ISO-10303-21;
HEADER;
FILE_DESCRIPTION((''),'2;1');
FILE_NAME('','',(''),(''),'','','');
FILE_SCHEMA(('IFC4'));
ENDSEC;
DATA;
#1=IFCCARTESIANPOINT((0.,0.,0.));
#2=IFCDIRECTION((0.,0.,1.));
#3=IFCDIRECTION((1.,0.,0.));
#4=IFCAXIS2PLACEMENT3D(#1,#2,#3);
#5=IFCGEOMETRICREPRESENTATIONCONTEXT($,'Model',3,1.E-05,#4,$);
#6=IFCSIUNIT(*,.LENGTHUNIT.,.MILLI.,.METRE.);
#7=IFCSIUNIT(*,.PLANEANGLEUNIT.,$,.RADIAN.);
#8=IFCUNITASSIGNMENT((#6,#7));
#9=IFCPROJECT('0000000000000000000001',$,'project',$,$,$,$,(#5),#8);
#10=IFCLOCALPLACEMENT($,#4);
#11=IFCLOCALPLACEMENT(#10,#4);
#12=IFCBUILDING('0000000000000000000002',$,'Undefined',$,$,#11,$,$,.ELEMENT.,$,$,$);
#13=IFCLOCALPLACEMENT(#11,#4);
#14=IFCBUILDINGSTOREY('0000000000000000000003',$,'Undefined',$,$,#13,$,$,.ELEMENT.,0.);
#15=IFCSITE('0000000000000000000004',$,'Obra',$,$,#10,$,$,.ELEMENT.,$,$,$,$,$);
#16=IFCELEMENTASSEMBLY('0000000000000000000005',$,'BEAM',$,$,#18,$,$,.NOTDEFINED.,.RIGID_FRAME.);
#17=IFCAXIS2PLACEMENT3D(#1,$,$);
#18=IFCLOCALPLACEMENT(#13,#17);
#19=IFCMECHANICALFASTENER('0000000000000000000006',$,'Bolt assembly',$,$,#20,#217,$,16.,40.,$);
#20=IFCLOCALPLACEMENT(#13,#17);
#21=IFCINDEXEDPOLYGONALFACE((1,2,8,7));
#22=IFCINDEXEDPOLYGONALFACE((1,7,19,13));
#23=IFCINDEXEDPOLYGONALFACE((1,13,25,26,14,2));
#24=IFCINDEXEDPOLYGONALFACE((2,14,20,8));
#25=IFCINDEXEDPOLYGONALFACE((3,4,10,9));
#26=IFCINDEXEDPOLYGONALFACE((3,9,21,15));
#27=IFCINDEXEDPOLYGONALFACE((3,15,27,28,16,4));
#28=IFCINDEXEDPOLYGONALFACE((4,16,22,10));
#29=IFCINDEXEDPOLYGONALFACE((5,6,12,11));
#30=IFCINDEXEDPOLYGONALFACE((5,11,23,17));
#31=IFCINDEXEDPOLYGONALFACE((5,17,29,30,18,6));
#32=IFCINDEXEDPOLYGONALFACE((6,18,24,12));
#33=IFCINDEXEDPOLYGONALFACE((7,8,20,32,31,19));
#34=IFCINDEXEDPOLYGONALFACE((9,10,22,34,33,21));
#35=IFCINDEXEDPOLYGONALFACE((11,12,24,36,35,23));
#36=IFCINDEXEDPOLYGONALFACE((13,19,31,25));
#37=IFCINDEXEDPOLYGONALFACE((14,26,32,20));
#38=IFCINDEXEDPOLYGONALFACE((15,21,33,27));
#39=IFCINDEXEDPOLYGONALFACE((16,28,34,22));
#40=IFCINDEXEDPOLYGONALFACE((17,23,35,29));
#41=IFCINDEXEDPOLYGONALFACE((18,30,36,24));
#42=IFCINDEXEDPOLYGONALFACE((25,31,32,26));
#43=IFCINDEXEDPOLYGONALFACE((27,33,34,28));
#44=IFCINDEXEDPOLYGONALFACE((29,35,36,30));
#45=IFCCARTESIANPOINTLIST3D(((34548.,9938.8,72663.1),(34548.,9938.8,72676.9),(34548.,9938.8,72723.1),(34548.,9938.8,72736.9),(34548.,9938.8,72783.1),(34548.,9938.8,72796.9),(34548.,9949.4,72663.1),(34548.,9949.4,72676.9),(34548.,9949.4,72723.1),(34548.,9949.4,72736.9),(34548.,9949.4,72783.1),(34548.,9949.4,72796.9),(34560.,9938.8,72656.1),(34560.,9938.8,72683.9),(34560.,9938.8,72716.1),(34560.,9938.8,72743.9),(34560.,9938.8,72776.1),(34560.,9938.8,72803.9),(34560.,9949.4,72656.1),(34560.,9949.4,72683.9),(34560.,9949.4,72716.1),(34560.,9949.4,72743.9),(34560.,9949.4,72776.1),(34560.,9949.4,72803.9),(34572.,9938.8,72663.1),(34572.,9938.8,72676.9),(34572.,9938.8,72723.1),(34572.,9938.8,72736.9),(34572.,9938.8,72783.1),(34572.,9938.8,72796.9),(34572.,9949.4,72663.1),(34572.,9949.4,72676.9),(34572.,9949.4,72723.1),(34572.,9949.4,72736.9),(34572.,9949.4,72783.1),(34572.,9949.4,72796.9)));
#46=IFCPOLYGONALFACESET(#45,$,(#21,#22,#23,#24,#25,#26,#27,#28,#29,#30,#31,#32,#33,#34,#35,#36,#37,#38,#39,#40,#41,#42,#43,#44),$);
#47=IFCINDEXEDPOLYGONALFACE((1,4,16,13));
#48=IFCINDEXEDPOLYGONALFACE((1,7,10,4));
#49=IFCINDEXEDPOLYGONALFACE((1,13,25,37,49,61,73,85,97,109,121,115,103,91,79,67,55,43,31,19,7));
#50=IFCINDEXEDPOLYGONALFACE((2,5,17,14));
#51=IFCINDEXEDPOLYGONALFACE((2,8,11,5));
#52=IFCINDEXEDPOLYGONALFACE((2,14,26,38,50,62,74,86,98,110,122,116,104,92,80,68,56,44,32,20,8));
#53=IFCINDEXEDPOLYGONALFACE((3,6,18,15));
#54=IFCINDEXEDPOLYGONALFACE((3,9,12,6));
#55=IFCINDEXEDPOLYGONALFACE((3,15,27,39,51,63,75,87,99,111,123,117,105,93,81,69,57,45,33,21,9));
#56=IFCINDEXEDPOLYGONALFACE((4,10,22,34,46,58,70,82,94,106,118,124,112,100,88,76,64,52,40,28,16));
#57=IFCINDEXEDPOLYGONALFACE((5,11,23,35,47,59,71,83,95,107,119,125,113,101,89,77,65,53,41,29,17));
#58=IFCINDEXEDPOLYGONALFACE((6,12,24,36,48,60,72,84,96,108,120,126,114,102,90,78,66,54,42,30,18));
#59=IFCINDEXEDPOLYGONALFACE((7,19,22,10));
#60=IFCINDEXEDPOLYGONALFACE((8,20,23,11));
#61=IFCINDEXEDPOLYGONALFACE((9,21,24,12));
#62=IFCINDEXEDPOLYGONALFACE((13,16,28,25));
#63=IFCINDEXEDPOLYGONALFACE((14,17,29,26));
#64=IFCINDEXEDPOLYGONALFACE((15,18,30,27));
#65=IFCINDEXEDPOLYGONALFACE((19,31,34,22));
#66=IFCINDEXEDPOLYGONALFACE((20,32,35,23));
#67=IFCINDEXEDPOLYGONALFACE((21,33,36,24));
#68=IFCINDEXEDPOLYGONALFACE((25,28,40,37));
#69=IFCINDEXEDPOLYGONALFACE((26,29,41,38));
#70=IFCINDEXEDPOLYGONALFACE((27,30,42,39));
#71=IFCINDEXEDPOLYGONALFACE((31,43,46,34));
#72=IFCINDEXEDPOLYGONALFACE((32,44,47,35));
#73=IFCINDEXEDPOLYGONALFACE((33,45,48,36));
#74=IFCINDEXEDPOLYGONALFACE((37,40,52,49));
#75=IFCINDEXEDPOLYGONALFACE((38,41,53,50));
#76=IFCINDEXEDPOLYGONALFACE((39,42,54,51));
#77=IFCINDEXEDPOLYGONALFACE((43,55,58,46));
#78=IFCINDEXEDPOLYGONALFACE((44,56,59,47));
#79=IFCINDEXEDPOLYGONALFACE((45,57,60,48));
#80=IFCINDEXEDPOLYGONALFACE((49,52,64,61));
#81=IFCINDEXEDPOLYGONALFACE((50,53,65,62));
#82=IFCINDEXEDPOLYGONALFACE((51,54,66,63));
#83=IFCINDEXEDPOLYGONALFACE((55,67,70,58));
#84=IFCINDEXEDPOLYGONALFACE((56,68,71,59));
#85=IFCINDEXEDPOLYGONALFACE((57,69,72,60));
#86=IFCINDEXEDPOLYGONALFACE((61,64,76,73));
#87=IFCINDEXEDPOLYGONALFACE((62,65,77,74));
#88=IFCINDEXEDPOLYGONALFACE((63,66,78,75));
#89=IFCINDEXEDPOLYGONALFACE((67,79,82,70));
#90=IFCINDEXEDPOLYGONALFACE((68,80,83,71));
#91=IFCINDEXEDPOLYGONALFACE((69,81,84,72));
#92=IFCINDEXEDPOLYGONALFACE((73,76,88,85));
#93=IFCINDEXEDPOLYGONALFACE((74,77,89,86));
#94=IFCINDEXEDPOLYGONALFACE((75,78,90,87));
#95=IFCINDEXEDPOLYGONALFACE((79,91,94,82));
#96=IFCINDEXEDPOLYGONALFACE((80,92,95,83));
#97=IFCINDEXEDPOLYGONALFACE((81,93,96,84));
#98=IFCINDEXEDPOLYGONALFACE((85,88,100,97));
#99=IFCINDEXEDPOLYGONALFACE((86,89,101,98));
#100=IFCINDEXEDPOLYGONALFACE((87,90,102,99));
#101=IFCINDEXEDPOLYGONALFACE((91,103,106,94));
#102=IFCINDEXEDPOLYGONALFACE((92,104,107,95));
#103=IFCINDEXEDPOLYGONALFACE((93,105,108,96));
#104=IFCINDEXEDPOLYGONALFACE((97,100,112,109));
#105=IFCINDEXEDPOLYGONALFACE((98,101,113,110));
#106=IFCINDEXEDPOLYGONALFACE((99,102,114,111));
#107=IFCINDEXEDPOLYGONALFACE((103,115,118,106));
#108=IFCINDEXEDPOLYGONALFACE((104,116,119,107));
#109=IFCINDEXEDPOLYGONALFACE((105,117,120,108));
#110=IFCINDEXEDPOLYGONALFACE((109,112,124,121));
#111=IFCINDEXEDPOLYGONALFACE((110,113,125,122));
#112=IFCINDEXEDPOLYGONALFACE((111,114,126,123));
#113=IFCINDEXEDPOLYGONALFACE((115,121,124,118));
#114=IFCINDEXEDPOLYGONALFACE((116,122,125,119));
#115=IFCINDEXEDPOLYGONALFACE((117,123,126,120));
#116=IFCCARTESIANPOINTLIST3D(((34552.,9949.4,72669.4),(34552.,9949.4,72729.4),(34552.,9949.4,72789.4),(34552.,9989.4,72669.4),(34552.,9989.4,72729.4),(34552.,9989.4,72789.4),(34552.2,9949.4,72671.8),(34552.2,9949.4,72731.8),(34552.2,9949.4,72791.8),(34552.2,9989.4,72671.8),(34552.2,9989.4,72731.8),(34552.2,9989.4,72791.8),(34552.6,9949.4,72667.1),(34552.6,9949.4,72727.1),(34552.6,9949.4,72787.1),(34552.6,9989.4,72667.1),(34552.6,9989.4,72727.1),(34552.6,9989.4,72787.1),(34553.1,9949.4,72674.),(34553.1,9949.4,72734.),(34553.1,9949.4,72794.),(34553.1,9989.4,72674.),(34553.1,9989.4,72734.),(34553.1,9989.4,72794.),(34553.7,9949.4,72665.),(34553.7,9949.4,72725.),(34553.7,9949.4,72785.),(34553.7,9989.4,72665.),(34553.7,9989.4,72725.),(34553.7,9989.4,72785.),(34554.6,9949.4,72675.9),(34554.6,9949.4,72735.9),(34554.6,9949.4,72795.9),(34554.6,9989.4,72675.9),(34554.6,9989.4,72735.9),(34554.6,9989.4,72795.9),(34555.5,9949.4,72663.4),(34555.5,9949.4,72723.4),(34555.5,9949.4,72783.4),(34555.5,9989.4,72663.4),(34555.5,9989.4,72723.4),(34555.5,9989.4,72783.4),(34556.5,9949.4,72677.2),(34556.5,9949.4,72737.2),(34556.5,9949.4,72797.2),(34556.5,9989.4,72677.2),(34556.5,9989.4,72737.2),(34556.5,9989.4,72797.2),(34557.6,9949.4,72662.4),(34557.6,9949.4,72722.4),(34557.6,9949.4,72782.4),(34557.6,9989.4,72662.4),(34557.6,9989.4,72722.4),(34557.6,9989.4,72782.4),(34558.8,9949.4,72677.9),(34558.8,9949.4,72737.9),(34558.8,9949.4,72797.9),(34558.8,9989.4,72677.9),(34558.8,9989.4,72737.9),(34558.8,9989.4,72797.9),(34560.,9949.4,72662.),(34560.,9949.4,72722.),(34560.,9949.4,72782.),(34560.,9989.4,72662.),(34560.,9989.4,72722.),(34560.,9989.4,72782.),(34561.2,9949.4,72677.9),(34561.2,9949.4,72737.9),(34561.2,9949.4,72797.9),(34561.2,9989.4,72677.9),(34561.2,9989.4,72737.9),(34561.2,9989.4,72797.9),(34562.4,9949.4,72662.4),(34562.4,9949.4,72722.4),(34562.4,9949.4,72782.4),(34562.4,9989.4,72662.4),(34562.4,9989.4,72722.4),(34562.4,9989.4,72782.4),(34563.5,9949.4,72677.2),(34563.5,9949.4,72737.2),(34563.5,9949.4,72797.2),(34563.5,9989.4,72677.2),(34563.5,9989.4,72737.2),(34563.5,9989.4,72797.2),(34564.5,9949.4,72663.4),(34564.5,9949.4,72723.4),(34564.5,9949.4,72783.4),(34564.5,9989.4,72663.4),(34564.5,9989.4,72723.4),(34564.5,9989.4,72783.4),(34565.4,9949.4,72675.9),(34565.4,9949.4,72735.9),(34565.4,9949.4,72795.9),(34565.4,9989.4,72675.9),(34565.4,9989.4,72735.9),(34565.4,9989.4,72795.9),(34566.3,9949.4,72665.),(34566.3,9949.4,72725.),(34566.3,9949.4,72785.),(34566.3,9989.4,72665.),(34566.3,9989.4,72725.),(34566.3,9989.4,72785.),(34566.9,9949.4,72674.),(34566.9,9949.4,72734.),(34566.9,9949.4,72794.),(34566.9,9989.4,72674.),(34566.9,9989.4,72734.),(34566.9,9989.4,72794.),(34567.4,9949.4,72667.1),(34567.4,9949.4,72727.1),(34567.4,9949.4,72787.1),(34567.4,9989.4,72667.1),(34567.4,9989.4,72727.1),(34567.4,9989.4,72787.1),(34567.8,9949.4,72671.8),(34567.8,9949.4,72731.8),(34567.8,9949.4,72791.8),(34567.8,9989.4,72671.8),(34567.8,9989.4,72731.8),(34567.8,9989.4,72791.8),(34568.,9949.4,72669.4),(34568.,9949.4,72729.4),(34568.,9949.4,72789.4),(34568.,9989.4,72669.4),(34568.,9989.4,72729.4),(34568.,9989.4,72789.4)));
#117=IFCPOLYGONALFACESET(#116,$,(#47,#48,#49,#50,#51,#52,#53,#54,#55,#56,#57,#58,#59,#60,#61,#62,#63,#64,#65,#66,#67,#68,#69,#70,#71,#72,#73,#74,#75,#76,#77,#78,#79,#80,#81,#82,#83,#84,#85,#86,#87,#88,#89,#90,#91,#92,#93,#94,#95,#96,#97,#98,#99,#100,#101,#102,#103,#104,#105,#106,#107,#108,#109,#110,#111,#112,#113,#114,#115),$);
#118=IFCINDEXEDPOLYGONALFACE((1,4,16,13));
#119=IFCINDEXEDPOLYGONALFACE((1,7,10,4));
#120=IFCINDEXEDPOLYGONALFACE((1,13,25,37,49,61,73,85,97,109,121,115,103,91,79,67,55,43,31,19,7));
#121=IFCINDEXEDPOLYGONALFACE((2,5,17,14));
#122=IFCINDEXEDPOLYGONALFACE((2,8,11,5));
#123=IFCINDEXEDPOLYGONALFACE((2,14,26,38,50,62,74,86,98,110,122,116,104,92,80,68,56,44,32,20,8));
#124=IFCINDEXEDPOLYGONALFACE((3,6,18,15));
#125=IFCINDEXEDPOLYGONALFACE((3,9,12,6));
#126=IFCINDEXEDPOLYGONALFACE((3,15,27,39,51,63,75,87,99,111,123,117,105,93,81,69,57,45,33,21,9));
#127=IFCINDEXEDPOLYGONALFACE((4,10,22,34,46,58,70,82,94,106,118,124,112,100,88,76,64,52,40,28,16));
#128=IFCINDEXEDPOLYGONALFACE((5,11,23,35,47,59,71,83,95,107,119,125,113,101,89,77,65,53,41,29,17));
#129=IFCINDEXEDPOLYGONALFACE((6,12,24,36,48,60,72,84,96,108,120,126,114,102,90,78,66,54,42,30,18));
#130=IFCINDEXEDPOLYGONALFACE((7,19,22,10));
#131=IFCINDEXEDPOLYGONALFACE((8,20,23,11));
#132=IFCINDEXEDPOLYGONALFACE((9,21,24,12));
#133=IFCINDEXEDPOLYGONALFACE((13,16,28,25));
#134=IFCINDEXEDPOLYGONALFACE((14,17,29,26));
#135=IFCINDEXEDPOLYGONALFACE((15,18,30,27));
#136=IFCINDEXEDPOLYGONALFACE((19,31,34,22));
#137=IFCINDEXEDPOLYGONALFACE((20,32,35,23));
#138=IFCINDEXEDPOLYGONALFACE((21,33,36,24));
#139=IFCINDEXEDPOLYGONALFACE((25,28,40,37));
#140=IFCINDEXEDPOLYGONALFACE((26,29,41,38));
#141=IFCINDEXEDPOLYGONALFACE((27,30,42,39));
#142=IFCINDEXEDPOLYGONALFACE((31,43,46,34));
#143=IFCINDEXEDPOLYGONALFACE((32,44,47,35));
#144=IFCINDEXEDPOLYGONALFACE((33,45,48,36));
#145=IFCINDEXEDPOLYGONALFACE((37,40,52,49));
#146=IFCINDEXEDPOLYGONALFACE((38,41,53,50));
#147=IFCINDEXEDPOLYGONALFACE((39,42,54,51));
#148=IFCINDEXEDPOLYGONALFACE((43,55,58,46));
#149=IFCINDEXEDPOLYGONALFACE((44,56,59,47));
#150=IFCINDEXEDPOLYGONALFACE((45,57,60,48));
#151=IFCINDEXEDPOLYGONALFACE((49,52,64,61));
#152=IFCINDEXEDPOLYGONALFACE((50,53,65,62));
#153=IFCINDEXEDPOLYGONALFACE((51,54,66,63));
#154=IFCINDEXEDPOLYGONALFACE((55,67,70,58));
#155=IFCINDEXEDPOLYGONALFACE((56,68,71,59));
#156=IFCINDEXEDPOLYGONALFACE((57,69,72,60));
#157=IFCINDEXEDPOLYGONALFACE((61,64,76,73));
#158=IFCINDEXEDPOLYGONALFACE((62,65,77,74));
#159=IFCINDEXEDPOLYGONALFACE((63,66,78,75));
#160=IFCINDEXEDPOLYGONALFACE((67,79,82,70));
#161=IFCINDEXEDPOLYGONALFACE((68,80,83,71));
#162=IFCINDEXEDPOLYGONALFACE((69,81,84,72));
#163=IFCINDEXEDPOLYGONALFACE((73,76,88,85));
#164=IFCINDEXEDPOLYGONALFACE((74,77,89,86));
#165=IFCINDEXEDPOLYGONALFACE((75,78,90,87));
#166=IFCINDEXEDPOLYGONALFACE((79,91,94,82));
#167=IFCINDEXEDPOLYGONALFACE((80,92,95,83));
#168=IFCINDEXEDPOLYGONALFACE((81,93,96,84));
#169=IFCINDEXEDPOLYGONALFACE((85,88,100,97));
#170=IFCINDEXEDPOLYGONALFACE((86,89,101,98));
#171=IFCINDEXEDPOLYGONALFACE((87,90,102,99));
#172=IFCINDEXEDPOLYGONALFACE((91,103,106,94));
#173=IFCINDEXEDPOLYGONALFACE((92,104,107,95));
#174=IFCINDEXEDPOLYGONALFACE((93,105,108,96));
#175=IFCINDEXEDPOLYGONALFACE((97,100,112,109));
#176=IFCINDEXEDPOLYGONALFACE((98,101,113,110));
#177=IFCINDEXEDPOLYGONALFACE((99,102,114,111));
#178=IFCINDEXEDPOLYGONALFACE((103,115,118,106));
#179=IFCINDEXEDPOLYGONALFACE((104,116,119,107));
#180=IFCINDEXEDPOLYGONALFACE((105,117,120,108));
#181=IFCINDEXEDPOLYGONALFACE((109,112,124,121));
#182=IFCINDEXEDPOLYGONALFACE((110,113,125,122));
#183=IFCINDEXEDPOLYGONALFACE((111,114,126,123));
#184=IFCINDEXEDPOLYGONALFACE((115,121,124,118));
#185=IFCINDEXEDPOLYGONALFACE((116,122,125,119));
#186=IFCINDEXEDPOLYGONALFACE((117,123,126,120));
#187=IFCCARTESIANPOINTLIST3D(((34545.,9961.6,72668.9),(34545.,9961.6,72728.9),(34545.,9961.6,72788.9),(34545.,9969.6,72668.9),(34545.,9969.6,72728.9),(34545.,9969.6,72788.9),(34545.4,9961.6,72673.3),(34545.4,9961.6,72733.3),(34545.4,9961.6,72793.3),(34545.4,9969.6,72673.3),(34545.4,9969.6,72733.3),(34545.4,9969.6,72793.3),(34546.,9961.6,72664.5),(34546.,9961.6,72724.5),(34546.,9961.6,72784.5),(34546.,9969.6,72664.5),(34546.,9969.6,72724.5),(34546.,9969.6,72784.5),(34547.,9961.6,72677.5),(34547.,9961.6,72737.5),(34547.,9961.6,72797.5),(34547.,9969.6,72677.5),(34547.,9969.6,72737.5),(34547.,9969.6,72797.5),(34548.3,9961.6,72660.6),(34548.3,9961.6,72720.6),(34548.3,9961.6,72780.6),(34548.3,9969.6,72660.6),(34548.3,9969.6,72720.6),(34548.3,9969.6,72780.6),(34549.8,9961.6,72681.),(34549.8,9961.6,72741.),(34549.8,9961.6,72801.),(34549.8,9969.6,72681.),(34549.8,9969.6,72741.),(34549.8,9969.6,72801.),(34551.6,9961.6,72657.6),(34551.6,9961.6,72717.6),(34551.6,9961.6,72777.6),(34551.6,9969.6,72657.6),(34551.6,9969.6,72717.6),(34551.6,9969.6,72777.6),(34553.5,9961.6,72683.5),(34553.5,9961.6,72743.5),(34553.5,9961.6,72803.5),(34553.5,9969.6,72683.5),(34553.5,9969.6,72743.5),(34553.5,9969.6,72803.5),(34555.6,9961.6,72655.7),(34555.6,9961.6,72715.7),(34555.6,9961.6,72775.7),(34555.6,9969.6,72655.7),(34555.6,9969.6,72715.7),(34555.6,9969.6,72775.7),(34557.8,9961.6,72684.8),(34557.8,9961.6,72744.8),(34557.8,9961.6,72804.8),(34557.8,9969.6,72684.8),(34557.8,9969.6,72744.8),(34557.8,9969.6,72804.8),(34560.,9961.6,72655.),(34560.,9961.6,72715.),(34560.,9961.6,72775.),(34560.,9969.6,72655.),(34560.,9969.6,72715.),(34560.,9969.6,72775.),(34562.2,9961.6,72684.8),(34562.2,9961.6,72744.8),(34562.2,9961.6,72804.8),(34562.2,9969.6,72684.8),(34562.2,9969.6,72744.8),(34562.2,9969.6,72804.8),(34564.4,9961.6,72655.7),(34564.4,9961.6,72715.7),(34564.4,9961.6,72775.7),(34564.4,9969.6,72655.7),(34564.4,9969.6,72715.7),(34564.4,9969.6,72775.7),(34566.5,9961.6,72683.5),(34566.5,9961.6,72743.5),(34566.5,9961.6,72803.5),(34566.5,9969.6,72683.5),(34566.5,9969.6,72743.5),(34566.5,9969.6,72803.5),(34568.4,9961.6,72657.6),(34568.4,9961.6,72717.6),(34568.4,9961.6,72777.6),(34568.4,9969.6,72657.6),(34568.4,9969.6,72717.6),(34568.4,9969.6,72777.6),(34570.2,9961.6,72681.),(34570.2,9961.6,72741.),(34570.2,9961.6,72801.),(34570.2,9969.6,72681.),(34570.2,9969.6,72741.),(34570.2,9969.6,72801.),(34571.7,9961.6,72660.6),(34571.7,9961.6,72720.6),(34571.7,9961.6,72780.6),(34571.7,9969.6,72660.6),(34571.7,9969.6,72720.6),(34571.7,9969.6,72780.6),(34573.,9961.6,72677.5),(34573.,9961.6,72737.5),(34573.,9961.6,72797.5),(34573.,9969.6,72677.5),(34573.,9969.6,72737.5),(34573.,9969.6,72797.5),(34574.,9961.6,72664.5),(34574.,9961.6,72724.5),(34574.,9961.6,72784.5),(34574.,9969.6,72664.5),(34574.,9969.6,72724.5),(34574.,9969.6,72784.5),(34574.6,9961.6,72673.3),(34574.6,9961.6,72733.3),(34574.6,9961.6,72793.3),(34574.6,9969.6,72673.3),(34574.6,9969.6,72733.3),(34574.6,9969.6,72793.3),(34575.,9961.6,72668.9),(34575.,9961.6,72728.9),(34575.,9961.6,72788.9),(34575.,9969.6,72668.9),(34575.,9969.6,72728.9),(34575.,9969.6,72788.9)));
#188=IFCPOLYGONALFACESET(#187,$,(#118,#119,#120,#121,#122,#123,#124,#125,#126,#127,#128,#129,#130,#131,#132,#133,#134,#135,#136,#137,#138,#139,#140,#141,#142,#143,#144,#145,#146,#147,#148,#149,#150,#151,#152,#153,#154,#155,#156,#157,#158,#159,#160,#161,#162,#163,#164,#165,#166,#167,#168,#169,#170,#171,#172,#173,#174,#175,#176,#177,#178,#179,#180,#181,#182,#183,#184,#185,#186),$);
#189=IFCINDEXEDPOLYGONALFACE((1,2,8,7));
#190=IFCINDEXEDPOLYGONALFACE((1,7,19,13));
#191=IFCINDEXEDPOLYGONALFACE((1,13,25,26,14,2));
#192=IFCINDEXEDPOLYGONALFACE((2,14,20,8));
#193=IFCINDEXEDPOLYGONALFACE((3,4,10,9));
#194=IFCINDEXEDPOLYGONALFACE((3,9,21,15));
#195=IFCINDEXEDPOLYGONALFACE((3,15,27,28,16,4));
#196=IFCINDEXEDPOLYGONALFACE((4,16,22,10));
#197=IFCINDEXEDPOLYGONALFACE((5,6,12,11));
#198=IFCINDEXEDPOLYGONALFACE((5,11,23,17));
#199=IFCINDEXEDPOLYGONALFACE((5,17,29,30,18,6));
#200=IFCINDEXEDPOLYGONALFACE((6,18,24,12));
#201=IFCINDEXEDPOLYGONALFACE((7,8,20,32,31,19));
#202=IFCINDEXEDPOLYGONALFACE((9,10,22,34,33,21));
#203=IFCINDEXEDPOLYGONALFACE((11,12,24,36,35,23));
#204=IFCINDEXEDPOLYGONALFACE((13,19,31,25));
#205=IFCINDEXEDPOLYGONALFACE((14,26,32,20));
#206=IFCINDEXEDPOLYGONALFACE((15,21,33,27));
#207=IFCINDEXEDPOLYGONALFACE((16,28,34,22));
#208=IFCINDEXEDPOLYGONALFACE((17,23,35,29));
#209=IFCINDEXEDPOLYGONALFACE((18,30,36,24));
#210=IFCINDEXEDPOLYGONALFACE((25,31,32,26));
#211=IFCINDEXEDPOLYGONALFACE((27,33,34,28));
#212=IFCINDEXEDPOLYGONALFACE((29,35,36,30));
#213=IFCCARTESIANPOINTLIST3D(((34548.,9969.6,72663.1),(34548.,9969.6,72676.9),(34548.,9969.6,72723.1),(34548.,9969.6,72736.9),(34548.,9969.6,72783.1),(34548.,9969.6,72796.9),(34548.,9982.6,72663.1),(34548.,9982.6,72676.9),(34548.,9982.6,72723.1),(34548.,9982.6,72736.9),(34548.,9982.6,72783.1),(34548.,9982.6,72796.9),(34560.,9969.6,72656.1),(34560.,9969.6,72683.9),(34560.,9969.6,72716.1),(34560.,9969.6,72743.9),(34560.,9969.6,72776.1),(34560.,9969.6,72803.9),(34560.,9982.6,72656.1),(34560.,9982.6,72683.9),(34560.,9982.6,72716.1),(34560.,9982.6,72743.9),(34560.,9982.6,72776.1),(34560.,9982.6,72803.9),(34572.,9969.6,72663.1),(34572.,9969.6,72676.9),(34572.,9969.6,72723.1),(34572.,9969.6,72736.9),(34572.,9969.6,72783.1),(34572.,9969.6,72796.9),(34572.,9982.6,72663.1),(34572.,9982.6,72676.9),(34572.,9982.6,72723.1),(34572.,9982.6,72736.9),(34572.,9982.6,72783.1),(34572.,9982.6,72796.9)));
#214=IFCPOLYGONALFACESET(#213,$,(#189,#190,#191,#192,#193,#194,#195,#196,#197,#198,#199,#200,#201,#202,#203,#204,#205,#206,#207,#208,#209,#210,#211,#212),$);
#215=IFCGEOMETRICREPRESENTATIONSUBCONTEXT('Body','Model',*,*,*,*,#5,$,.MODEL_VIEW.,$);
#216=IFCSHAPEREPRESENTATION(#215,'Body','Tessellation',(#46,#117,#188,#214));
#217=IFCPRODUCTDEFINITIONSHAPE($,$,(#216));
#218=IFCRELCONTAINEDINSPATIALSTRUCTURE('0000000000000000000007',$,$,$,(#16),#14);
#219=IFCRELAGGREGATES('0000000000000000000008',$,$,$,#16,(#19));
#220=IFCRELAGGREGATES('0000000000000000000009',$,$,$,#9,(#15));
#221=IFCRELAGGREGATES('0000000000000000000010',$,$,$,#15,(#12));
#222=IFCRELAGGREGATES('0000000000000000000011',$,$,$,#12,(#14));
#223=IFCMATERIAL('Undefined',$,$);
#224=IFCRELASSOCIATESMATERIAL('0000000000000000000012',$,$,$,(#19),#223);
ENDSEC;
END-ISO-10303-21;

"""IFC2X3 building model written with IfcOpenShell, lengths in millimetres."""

from ifc_helpers import new_model, si_unit, frame, origin_with_axes, origin_2d_with_axis, place, context, subcontext, project, spatial, polyline, circle, outline, extrude, source, transform, mapped, material, element, aggregate, save


model = new_model("IFC2X3")

# Units and contexts
model_context = context("Model", 3, precision=1e-05, world=origin_with_axes())
body_context = subcontext(model_context, "Body", "Model", "MODEL_VIEW")
ifc_project = project(units=[si_unit("LENGTHUNIT", "METRE", prefix="MILLI"), si_unit("PLANEANGLEUNIT", "RADIAN")], contexts=[model_context])

# Site, building, storey
site_placement = place(None, origin_with_axes())
site = spatial("IfcSite", under=ifc_project, at=site_placement, Name="Obra", CompositionType="ELEMENT")
building_placement = place(site_placement, origin_with_axes())
building = spatial("IfcBuilding", under=site, at=building_placement, Name="Undefined", CompositionType="ELEMENT")
storey_placement = place(building_placement, origin_with_axes())
storey = spatial("IfcBuildingStorey", under=building, at=storey_placement, Name="Undefined", CompositionType="ELEMENT", Elevation=0.0)

# Shared definitions
ifc_material = material(Name="Undefined")

# Element assembly, mechanical fastener
assembly_1_placement = place(storey_placement, origin_with_axes())
assembly_1 = element("IfcElementAssembly", 1, at=assembly_1_placement, inside=storey, Name="BEAM", AssemblyPlace="NOTDEFINED", PredefinedType="RIGID_FRAME")
shared_shape_1 = source(origin_with_axes(), body_context, "Body", "SweptSolid", [
    extrude(outline(polyline([(13.9, 0.0), (6.9, 12.0), (-6.9, 12.0), (-13.9, 0.0), (-6.9, -12.0), (6.9, -12.0), (13.9, 0.0)])), frame((0.0, -19.7, 0.0), z_axis=(0.0, 1.0, 0.0), x_axis=(1.0, 0.0, 0.0)), (0.0, 0.0, 1.0), 10.6),
    extrude(circle(Radius=8.0, at=origin_2d_with_axis()), frame((0.0, -9.1, 0.0), z_axis=(0.0, 1.0, 0.0), x_axis=(1.0, 0.0, 0.0)), (0.0, 0.0, 1.0), 40.0),
    extrude(circle(Radius=15.0, at=origin_2d_with_axis()), frame((0.0, 3.1, 0.0), z_axis=(0.0, 1.0, 0.0), x_axis=(1.0, 0.0, 0.0)), (0.0, 0.0, 1.0), 8.0),
    extrude(outline(polyline([(13.9, 0.0), (6.9, 12.0), (-6.9, 12.0), (-13.9, 0.0), (-6.9, -12.0), (6.9, -12.0), (13.9, 0.0)])), frame((0.0, 11.1, 0.0), z_axis=(0.0, 1.0, 0.0), x_axis=(1.0, 0.0, 0.0)), (0.0, 0.0, 1.0), 13.0),
])
mechanical_fastener_1_placement = place(assembly_1_placement, frame((34510.0, 9958.5, 72850.0), z_axis=(1.0, 0.0, 0.0), x_axis=(0.0, 0.0, -1.0)))
mechanical_fastener_1 = element("IfcMechanicalFastener", 2, at=mechanical_fastener_1_placement, material=ifc_material, Name="Bolt assembly", NominalDiameter=16.0, NominalLength=40.0, context=body_context, shape_type="MappedRepresentation", body=[
    mapped(shared_shape_1, transform((60.0, 0.0, 50.0))),
    mapped(shared_shape_1, transform((120.0, 0.0, 50.0))),
    mapped(shared_shape_1, transform((180.0, 0.0, 50.0))),
])
aggregate(assembly_1, [mechanical_fastener_1])

save(model, "model.ifc")
